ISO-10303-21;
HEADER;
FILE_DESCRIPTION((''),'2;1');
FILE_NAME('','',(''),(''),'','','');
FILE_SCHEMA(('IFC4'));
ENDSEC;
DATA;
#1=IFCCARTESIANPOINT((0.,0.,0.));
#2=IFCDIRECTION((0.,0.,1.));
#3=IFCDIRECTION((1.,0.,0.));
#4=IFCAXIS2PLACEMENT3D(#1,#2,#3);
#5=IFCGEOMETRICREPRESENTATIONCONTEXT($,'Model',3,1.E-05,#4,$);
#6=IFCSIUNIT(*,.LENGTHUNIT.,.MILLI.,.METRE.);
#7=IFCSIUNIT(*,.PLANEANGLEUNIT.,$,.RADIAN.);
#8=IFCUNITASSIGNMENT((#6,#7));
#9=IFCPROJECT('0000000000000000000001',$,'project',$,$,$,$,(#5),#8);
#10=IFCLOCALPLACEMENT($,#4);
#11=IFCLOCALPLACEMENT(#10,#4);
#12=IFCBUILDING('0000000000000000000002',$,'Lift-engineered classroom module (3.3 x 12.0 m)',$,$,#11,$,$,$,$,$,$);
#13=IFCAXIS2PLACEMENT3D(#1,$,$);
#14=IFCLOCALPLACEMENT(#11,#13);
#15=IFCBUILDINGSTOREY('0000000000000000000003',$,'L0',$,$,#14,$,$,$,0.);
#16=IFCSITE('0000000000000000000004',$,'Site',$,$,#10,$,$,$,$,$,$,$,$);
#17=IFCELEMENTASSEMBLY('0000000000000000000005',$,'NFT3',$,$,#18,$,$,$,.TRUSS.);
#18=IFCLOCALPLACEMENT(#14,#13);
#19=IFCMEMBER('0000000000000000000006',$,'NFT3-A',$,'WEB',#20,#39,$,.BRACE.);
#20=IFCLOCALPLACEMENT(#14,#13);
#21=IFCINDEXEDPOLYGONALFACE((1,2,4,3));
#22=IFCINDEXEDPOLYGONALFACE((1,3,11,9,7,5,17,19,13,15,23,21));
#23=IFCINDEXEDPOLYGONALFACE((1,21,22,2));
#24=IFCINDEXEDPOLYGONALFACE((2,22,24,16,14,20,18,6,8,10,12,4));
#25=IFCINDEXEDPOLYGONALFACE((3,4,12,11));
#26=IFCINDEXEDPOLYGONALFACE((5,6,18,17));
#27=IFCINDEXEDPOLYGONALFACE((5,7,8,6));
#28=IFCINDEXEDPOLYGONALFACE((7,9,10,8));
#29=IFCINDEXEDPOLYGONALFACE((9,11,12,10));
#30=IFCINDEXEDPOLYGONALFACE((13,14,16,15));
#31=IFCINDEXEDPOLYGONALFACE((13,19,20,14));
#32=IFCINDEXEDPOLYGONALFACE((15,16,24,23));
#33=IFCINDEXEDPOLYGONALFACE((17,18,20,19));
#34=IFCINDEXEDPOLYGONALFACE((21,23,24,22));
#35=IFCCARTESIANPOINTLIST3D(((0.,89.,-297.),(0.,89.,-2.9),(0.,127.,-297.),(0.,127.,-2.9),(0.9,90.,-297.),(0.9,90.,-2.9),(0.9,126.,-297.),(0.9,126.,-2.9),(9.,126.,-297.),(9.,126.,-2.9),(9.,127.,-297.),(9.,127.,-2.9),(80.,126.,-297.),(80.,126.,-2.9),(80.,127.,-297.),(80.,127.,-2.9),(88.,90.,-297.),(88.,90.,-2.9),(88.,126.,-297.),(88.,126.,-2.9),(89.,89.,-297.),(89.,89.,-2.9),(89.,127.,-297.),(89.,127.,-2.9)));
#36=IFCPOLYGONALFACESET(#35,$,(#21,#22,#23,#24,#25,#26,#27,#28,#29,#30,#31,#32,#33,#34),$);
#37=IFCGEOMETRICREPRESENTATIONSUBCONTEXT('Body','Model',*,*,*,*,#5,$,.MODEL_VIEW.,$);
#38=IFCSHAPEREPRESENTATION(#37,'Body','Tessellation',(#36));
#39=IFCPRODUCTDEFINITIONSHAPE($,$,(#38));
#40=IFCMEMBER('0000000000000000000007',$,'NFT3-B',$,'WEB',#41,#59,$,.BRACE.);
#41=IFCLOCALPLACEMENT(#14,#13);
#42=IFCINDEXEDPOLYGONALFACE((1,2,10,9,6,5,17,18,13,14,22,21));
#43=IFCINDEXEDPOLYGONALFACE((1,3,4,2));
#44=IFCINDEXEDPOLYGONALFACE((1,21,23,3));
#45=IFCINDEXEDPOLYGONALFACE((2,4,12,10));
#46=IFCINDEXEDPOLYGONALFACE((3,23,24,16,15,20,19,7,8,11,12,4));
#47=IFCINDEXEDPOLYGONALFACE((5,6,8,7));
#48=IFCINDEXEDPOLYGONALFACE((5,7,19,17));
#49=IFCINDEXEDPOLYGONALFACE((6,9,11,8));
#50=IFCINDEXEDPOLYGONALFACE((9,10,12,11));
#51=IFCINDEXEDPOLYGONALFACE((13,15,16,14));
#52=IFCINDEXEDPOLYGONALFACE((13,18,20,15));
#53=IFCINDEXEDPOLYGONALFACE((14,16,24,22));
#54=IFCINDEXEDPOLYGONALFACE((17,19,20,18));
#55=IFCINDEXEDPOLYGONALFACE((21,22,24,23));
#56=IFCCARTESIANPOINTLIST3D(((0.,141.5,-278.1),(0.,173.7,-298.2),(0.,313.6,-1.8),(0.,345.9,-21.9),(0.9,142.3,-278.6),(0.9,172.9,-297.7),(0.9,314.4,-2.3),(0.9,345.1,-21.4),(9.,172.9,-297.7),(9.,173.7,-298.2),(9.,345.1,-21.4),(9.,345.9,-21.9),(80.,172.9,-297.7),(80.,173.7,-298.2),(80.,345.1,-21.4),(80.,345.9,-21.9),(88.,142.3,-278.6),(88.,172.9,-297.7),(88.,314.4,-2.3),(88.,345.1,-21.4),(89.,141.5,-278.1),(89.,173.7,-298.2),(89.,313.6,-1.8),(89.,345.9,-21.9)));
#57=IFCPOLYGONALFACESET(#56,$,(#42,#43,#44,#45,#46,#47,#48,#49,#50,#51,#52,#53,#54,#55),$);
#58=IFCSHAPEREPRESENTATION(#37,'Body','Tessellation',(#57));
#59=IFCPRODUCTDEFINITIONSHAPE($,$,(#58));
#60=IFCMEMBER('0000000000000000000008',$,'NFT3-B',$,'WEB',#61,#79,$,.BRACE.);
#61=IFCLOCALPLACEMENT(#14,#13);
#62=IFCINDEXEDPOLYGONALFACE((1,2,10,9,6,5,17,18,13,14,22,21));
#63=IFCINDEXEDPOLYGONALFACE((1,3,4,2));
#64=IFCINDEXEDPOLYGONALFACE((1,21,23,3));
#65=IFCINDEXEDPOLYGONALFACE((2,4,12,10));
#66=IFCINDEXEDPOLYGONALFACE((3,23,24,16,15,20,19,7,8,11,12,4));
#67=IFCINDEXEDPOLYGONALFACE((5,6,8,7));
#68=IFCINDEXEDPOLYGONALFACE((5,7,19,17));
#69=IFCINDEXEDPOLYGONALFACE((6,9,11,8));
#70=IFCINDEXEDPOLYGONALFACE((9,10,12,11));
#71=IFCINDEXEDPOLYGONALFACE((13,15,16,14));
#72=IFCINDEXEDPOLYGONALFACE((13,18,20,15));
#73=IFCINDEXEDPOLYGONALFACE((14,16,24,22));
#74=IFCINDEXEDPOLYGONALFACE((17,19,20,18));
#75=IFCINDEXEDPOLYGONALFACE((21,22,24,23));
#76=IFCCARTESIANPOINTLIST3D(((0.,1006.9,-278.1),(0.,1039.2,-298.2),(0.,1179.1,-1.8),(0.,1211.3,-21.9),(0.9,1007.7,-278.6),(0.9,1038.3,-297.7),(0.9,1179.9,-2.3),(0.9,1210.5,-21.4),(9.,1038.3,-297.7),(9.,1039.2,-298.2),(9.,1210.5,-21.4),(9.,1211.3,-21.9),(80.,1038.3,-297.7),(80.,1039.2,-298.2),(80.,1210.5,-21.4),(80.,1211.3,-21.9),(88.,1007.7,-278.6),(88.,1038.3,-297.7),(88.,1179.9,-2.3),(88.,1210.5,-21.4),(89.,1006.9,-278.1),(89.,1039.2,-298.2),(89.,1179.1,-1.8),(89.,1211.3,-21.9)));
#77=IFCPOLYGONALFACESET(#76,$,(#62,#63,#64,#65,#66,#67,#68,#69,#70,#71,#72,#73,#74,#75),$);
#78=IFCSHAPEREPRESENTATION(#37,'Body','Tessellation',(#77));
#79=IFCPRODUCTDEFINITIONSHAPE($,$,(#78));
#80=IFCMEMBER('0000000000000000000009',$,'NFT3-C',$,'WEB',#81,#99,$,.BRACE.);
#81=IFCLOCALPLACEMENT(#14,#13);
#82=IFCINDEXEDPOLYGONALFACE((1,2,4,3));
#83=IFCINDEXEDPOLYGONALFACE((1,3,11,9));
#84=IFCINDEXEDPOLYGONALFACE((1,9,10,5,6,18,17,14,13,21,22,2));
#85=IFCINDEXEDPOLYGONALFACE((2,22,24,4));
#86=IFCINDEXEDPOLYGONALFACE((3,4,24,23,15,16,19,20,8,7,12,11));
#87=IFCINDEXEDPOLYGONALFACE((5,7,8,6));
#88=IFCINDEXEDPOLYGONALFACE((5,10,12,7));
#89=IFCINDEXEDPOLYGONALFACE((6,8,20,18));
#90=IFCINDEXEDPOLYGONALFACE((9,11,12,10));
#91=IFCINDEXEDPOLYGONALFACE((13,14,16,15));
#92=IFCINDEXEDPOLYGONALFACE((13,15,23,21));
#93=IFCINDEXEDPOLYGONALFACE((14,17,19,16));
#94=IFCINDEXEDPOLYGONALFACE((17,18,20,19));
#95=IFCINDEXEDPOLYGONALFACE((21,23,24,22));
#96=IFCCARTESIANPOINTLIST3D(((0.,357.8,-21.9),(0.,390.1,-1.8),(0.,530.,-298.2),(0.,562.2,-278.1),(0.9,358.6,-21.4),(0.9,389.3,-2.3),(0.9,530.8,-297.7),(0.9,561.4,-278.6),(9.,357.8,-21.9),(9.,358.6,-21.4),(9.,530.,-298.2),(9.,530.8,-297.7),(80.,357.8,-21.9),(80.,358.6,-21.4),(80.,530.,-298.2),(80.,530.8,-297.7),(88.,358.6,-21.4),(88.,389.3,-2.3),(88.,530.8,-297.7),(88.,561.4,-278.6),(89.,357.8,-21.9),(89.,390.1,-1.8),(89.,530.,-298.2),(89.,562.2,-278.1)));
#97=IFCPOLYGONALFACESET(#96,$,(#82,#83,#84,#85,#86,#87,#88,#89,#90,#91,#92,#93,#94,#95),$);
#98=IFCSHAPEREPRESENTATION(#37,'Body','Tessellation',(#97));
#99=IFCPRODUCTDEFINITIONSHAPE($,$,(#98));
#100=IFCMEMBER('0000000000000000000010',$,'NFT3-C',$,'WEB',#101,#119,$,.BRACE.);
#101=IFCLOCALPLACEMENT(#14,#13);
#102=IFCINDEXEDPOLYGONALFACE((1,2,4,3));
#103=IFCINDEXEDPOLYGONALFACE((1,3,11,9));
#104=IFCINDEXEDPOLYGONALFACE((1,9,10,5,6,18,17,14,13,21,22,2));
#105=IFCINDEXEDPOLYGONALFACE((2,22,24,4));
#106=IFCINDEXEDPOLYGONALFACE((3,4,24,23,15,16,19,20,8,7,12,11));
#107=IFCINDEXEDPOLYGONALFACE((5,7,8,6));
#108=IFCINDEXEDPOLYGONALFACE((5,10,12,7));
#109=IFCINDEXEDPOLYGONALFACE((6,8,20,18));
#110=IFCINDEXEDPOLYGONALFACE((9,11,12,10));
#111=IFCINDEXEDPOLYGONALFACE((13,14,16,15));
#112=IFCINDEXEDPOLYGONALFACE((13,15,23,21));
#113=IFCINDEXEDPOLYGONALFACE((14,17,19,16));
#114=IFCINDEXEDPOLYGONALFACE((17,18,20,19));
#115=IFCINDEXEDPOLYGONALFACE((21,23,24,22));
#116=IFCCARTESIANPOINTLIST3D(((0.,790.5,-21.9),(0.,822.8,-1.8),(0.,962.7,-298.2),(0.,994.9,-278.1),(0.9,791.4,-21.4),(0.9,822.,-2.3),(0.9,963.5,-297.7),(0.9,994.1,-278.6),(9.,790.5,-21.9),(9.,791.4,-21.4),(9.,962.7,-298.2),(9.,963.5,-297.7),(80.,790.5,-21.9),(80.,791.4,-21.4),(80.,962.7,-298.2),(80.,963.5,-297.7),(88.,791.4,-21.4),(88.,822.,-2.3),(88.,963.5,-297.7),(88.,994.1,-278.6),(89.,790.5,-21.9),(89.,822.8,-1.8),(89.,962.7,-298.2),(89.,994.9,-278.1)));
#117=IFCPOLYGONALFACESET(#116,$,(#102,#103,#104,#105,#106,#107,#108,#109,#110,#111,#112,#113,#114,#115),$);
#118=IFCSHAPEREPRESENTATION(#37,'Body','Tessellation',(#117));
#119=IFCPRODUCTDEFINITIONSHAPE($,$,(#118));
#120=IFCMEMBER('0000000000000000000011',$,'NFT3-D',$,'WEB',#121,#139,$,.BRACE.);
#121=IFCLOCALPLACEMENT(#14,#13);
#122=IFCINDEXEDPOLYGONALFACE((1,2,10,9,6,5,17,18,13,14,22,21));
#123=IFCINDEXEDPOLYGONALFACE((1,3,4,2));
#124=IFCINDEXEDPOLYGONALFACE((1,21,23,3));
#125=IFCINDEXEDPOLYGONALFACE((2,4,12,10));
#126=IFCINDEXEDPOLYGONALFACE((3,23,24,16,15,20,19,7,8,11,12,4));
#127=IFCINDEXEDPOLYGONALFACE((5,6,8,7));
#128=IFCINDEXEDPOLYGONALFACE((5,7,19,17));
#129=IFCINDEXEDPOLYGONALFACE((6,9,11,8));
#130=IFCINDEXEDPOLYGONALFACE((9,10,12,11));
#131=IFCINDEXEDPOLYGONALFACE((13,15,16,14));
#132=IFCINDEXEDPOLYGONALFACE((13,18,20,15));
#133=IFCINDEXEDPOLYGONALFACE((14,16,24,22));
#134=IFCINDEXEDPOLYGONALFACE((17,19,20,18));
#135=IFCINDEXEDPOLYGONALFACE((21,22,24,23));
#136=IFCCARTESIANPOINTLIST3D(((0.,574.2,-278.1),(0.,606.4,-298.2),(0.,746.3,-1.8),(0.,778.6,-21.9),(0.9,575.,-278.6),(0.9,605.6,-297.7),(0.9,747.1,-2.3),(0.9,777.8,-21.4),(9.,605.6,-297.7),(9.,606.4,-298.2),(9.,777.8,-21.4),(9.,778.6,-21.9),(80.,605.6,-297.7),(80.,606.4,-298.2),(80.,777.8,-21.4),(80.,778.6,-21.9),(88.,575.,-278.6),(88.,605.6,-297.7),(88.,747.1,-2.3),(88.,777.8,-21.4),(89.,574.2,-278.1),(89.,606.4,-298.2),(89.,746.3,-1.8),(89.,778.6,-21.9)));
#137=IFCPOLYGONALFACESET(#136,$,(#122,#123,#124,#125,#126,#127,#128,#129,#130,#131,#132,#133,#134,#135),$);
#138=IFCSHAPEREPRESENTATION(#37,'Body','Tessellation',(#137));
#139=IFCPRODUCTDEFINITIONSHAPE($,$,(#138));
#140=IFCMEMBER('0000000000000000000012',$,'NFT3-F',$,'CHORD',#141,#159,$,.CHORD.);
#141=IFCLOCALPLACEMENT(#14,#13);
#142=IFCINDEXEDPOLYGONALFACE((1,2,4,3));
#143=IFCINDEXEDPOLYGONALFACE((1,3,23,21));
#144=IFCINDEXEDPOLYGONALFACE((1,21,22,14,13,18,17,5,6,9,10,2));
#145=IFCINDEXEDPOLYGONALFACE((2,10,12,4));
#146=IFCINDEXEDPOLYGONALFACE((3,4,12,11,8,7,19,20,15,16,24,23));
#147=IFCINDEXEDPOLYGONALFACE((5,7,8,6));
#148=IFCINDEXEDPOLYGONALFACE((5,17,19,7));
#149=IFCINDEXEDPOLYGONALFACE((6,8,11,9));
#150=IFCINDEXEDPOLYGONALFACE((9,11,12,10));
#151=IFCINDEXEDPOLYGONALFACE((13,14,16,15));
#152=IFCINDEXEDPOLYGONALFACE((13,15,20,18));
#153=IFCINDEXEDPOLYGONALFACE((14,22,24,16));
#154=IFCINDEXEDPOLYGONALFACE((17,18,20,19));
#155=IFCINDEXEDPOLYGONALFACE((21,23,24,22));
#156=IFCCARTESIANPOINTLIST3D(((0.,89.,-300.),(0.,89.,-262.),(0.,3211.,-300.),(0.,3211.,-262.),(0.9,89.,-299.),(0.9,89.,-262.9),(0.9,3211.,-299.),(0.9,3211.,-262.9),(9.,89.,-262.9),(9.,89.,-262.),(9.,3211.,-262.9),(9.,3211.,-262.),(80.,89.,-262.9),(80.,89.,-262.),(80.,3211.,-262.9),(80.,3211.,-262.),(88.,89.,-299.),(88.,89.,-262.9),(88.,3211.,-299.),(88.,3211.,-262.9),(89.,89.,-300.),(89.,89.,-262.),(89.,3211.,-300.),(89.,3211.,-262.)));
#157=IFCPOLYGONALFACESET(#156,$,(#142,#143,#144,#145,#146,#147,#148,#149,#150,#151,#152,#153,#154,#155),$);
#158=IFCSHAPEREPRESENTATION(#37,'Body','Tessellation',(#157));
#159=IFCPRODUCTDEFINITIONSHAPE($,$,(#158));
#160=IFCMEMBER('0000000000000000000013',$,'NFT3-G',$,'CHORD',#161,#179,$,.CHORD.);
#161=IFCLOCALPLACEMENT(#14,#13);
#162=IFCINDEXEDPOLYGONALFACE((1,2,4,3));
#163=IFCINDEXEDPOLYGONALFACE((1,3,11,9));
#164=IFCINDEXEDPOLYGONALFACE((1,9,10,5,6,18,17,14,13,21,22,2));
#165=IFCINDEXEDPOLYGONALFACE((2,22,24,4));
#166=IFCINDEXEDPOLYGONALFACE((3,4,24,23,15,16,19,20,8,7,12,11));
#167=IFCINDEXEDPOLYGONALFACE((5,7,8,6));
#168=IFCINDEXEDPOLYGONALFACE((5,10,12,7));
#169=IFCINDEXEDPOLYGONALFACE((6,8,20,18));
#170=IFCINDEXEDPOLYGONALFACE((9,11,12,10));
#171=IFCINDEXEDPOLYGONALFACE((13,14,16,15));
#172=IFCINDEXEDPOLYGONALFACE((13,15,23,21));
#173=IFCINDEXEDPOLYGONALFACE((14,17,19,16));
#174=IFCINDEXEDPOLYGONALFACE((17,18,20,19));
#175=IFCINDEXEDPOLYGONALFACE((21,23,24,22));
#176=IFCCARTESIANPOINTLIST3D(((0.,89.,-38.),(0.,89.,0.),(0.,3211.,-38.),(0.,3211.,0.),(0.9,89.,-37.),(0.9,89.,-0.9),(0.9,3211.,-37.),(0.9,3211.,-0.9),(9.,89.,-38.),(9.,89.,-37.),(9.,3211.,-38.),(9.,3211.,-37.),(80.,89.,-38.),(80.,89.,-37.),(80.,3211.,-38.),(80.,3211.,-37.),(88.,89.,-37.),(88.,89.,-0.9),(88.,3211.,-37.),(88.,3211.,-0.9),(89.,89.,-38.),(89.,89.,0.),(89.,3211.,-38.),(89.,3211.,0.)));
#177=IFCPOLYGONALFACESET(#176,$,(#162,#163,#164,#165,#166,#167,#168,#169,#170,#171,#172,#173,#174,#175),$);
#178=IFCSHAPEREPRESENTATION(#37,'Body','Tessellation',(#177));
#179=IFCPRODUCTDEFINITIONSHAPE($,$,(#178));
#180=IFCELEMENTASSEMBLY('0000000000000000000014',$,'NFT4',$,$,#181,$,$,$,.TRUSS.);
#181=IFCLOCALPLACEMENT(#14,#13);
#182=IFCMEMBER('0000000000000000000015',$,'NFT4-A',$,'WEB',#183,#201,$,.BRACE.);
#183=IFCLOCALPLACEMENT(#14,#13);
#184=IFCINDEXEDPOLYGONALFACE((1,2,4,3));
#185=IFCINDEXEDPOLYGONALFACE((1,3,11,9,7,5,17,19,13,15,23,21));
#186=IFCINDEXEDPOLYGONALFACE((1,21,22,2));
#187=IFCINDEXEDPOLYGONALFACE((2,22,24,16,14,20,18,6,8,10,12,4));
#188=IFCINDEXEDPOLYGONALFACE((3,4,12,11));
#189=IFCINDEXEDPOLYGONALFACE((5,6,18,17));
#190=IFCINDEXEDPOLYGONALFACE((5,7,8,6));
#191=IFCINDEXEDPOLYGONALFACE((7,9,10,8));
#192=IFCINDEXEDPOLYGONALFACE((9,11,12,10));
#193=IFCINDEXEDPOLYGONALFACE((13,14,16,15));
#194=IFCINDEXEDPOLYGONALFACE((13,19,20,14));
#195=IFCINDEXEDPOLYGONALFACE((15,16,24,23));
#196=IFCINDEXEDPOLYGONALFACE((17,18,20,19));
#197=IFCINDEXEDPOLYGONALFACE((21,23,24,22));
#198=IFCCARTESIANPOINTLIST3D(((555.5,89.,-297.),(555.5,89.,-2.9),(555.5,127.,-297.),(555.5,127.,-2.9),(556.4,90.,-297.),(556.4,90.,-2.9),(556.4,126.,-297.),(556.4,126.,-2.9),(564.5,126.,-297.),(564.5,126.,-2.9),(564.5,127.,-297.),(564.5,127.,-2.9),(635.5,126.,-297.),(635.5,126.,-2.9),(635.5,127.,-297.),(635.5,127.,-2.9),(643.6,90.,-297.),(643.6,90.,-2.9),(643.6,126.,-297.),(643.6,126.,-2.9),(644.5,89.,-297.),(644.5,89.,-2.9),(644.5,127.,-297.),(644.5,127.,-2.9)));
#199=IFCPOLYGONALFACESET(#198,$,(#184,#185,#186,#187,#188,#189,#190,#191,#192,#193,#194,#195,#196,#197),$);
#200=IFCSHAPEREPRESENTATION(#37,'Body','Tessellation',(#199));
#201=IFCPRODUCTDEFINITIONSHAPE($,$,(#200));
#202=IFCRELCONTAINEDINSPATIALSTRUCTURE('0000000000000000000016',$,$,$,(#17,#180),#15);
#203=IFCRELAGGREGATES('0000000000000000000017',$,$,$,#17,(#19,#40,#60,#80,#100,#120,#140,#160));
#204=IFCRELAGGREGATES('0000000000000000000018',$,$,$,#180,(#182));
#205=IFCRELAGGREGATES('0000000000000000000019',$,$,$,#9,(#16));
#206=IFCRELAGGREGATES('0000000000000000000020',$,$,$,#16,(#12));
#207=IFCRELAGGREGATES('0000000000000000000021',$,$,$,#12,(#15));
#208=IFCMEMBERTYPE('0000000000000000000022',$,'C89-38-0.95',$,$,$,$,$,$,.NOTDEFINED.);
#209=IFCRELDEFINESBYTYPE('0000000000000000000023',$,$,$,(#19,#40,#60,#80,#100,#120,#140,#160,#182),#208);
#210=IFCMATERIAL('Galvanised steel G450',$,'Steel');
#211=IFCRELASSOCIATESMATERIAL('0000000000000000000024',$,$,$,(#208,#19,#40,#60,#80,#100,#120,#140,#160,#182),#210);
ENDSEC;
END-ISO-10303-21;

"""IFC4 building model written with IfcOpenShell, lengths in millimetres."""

from ifc_helpers import new_model, si_unit, frame, origin, origin_with_axes, origin_2d, place, context, subcontext, project, spatial, c_section, extrude, material, material_profile, profile_set, profile_usage, type_object, element, aggregate, save


model = new_model("IFC4")

# Units and contexts
model_context = context("Model", 3, precision=1e-05, world=origin_with_axes())
body_context = subcontext(model_context, "Body", "Model", "MODEL_VIEW")
ifc_project = project(units=[si_unit("LENGTHUNIT", "METRE", prefix="MILLI"), si_unit("PLANEANGLEUNIT", "RADIAN")], contexts=[model_context])

# Site, building, storey
site_placement = place(None, origin_with_axes())
site = spatial("IfcSite", under=ifc_project, at=site_placement, Name="Site")
building_placement = place(site_placement, origin_with_axes())
building = spatial("IfcBuilding", under=site, at=building_placement, Name="Lift-engineered classroom module (3.3 x 12.0 m)")
storey_placement = place(building_placement, origin())
storey = spatial("IfcBuildingStorey", under=building, at=storey_placement, Name="L0", Elevation=0.0)

# Element assemblies, members
assembly_1_placement = place(storey_placement, frame((44.5, 89.0, -300.0)))
assembly_1 = element("IfcElementAssembly", 1, at=assembly_1_placement, inside=storey, Name="NFT3", PredefinedType="TRUSS")
ifc_material = material(Name="Galvanised steel G450", Category="Steel")
ifc_material_profile_1 = material_profile(ifc_material, c_section(Depth=89.0, Width=38.0, WallThickness=0.9, Girth=9.0, at=origin_2d()), Name="C89-38-0.95")
ifc_profile_set_1 = profile_set([ifc_material_profile_1], Name="C89-38-0.95")
ifc_profile_usage_1 = profile_usage(ifc_profile_set_1)
member_type_1 = type_object("IfcMemberType", Name="C89-38-0.95", PredefinedType="NOTDEFINED", material=ifc_profile_set_1)
member_1_placement = place(assembly_1_placement, frame((0.0, 19.0, 2.9), z_axis=(0.0, 0.0, 1.0), x_axis=(0.0, 1.0, 0.0)))
member_1 = element("IfcMember", 2, at=member_1_placement, type_object=member_type_1, material=ifc_profile_usage_1, Name="NFT3-A", ObjectType="WEB", PredefinedType="BRACE", context=body_context, shape_type="SweptSolid", body=[
    extrude(c_section(Depth=89.0, Width=38.0, WallThickness=0.9, Girth=9.0, at=origin_2d()), origin(), (0.0, 0.0, 1.0), 294.1),
])
member_2_placement = place(assembly_1_placement, frame((0.0, 68.6, 11.8), z_axis=(0.0, 0.528797, 0.848748), x_axis=(0.0, 0.848748, -0.528797)))
member_2 = element("IfcMember", 3, at=member_2_placement, type_object=member_type_1, material=ifc_profile_usage_1, Name="NFT3-B", ObjectType="WEB", PredefinedType="BRACE", context=body_context, shape_type="SweptSolid", body=[
    extrude(c_section(Depth=89.0, Width=38.0, WallThickness=0.9, Girth=9.0, at=origin_2d()), origin(), (0.0, 0.0, 1.0), 325.6),
])
member_3_placement = place(assembly_1_placement, frame((0.0, 934.0, 11.8), z_axis=(0.0, 0.528797, 0.848748), x_axis=(0.0, 0.848748, -0.528797)))
member_3 = element("IfcMember", 4, at=member_3_placement, type_object=member_type_1, material=ifc_profile_usage_1, Name="NFT3-B", ObjectType="WEB", PredefinedType="BRACE", context=body_context, shape_type="SweptSolid", body=[
    extrude(c_section(Depth=89.0, Width=38.0, WallThickness=0.9, Girth=9.0, at=origin_2d()), origin(), (0.0, 0.0, 1.0), 325.6),
])
member_4_placement = place(assembly_1_placement, frame((0.0, 457.1, 11.8), z_axis=(0.0, -0.528797, 0.848748), x_axis=(0.0, -0.848748, -0.528797)))
member_4 = element("IfcMember", 5, at=member_4_placement, type_object=member_type_1, material=ifc_profile_usage_1, Name="NFT3-C", ObjectType="WEB", PredefinedType="BRACE", context=body_context, shape_type="SweptSolid", body=[
    extrude(c_section(Depth=89.0, Width=38.0, WallThickness=0.9, Girth=9.0, at=origin_2d()), origin(), (0.0, 0.0, 1.0), 325.6),
])
member_5_placement = place(assembly_1_placement, frame((0.0, 889.8, 11.8), z_axis=(0.0, -0.528797, 0.848748), x_axis=(0.0, -0.848748, -0.528797)))
member_5 = element("IfcMember", 6, at=member_5_placement, type_object=member_type_1, material=ifc_profile_usage_1, Name="NFT3-C", ObjectType="WEB", PredefinedType="BRACE", context=body_context, shape_type="SweptSolid", body=[
    extrude(c_section(Depth=89.0, Width=38.0, WallThickness=0.9, Girth=9.0, at=origin_2d()), origin(), (0.0, 0.0, 1.0), 325.6),
])
member_6_placement = place(assembly_1_placement, frame((0.0, 501.3, 11.8), z_axis=(0.0, 0.528775, 0.848762), x_axis=(0.0, 0.848762, -0.528775)))
member_6 = element("IfcMember", 7, at=member_6_placement, type_object=member_type_1, material=ifc_profile_usage_1, Name="NFT3-D", ObjectType="WEB", PredefinedType="BRACE", context=body_context, shape_type="SweptSolid", body=[
    extrude(c_section(Depth=89.0, Width=38.0, WallThickness=0.9, Girth=9.0, at=origin_2d()), origin(), (0.0, 0.0, 1.0), 325.6),
])
member_7_placement = place(assembly_1_placement, frame((0.0, 0.0, 19.0), z_axis=(0.0, 1.0, 0.0), x_axis=(0.0, 0.0, 1.0)))
member_7 = element("IfcMember", 8, at=member_7_placement, type_object=member_type_1, material=ifc_profile_usage_1, Name="NFT3-F", ObjectType="CHORD", PredefinedType="CHORD", context=body_context, shape_type="SweptSolid", body=[
    extrude(c_section(Depth=89.0, Width=38.0, WallThickness=0.9, Girth=9.0, at=origin_2d()), origin(), (0.0, 0.0, 1.0), 3122.0),
])
member_8_placement = place(assembly_1_placement, frame((0.0, 0.0, 281.0), z_axis=(0.0, 1.0, 0.0), x_axis=(0.0, 0.0, -1.0)))
member_8 = element("IfcMember", 9, at=member_8_placement, type_object=member_type_1, material=ifc_profile_usage_1, Name="NFT3-G", ObjectType="CHORD", PredefinedType="CHORD", context=body_context, shape_type="SweptSolid", body=[
    extrude(c_section(Depth=89.0, Width=38.0, WallThickness=0.9, Girth=9.0, at=origin_2d()), origin(), (0.0, 0.0, 1.0), 3122.0),
])
aggregate(assembly_1, [member_1, member_2, member_3, member_4, member_5, member_6, member_7, member_8])
assembly_2_placement = place(storey_placement, frame((600.0, 89.0, -300.0)))
assembly_2 = element("IfcElementAssembly", 10, at=assembly_2_placement, inside=storey, Name="NFT4", PredefinedType="TRUSS")
member_9_placement = place(assembly_2_placement, frame((0.0, 19.0, 2.9), z_axis=(0.0, 0.0, 1.0), x_axis=(0.0, 1.0, 0.0)))
member_9 = element("IfcMember", 11, at=member_9_placement, type_object=member_type_1, material=ifc_profile_usage_1, Name="NFT4-A", ObjectType="WEB", PredefinedType="BRACE", context=body_context, shape_type="SweptSolid", body=[
    extrude(c_section(Depth=89.0, Width=38.0, WallThickness=0.9, Girth=9.0, at=origin_2d()), origin(), (0.0, 0.0, 1.0), 294.1),
])
aggregate(assembly_2, [member_9])

save(model, "model.ifc")
